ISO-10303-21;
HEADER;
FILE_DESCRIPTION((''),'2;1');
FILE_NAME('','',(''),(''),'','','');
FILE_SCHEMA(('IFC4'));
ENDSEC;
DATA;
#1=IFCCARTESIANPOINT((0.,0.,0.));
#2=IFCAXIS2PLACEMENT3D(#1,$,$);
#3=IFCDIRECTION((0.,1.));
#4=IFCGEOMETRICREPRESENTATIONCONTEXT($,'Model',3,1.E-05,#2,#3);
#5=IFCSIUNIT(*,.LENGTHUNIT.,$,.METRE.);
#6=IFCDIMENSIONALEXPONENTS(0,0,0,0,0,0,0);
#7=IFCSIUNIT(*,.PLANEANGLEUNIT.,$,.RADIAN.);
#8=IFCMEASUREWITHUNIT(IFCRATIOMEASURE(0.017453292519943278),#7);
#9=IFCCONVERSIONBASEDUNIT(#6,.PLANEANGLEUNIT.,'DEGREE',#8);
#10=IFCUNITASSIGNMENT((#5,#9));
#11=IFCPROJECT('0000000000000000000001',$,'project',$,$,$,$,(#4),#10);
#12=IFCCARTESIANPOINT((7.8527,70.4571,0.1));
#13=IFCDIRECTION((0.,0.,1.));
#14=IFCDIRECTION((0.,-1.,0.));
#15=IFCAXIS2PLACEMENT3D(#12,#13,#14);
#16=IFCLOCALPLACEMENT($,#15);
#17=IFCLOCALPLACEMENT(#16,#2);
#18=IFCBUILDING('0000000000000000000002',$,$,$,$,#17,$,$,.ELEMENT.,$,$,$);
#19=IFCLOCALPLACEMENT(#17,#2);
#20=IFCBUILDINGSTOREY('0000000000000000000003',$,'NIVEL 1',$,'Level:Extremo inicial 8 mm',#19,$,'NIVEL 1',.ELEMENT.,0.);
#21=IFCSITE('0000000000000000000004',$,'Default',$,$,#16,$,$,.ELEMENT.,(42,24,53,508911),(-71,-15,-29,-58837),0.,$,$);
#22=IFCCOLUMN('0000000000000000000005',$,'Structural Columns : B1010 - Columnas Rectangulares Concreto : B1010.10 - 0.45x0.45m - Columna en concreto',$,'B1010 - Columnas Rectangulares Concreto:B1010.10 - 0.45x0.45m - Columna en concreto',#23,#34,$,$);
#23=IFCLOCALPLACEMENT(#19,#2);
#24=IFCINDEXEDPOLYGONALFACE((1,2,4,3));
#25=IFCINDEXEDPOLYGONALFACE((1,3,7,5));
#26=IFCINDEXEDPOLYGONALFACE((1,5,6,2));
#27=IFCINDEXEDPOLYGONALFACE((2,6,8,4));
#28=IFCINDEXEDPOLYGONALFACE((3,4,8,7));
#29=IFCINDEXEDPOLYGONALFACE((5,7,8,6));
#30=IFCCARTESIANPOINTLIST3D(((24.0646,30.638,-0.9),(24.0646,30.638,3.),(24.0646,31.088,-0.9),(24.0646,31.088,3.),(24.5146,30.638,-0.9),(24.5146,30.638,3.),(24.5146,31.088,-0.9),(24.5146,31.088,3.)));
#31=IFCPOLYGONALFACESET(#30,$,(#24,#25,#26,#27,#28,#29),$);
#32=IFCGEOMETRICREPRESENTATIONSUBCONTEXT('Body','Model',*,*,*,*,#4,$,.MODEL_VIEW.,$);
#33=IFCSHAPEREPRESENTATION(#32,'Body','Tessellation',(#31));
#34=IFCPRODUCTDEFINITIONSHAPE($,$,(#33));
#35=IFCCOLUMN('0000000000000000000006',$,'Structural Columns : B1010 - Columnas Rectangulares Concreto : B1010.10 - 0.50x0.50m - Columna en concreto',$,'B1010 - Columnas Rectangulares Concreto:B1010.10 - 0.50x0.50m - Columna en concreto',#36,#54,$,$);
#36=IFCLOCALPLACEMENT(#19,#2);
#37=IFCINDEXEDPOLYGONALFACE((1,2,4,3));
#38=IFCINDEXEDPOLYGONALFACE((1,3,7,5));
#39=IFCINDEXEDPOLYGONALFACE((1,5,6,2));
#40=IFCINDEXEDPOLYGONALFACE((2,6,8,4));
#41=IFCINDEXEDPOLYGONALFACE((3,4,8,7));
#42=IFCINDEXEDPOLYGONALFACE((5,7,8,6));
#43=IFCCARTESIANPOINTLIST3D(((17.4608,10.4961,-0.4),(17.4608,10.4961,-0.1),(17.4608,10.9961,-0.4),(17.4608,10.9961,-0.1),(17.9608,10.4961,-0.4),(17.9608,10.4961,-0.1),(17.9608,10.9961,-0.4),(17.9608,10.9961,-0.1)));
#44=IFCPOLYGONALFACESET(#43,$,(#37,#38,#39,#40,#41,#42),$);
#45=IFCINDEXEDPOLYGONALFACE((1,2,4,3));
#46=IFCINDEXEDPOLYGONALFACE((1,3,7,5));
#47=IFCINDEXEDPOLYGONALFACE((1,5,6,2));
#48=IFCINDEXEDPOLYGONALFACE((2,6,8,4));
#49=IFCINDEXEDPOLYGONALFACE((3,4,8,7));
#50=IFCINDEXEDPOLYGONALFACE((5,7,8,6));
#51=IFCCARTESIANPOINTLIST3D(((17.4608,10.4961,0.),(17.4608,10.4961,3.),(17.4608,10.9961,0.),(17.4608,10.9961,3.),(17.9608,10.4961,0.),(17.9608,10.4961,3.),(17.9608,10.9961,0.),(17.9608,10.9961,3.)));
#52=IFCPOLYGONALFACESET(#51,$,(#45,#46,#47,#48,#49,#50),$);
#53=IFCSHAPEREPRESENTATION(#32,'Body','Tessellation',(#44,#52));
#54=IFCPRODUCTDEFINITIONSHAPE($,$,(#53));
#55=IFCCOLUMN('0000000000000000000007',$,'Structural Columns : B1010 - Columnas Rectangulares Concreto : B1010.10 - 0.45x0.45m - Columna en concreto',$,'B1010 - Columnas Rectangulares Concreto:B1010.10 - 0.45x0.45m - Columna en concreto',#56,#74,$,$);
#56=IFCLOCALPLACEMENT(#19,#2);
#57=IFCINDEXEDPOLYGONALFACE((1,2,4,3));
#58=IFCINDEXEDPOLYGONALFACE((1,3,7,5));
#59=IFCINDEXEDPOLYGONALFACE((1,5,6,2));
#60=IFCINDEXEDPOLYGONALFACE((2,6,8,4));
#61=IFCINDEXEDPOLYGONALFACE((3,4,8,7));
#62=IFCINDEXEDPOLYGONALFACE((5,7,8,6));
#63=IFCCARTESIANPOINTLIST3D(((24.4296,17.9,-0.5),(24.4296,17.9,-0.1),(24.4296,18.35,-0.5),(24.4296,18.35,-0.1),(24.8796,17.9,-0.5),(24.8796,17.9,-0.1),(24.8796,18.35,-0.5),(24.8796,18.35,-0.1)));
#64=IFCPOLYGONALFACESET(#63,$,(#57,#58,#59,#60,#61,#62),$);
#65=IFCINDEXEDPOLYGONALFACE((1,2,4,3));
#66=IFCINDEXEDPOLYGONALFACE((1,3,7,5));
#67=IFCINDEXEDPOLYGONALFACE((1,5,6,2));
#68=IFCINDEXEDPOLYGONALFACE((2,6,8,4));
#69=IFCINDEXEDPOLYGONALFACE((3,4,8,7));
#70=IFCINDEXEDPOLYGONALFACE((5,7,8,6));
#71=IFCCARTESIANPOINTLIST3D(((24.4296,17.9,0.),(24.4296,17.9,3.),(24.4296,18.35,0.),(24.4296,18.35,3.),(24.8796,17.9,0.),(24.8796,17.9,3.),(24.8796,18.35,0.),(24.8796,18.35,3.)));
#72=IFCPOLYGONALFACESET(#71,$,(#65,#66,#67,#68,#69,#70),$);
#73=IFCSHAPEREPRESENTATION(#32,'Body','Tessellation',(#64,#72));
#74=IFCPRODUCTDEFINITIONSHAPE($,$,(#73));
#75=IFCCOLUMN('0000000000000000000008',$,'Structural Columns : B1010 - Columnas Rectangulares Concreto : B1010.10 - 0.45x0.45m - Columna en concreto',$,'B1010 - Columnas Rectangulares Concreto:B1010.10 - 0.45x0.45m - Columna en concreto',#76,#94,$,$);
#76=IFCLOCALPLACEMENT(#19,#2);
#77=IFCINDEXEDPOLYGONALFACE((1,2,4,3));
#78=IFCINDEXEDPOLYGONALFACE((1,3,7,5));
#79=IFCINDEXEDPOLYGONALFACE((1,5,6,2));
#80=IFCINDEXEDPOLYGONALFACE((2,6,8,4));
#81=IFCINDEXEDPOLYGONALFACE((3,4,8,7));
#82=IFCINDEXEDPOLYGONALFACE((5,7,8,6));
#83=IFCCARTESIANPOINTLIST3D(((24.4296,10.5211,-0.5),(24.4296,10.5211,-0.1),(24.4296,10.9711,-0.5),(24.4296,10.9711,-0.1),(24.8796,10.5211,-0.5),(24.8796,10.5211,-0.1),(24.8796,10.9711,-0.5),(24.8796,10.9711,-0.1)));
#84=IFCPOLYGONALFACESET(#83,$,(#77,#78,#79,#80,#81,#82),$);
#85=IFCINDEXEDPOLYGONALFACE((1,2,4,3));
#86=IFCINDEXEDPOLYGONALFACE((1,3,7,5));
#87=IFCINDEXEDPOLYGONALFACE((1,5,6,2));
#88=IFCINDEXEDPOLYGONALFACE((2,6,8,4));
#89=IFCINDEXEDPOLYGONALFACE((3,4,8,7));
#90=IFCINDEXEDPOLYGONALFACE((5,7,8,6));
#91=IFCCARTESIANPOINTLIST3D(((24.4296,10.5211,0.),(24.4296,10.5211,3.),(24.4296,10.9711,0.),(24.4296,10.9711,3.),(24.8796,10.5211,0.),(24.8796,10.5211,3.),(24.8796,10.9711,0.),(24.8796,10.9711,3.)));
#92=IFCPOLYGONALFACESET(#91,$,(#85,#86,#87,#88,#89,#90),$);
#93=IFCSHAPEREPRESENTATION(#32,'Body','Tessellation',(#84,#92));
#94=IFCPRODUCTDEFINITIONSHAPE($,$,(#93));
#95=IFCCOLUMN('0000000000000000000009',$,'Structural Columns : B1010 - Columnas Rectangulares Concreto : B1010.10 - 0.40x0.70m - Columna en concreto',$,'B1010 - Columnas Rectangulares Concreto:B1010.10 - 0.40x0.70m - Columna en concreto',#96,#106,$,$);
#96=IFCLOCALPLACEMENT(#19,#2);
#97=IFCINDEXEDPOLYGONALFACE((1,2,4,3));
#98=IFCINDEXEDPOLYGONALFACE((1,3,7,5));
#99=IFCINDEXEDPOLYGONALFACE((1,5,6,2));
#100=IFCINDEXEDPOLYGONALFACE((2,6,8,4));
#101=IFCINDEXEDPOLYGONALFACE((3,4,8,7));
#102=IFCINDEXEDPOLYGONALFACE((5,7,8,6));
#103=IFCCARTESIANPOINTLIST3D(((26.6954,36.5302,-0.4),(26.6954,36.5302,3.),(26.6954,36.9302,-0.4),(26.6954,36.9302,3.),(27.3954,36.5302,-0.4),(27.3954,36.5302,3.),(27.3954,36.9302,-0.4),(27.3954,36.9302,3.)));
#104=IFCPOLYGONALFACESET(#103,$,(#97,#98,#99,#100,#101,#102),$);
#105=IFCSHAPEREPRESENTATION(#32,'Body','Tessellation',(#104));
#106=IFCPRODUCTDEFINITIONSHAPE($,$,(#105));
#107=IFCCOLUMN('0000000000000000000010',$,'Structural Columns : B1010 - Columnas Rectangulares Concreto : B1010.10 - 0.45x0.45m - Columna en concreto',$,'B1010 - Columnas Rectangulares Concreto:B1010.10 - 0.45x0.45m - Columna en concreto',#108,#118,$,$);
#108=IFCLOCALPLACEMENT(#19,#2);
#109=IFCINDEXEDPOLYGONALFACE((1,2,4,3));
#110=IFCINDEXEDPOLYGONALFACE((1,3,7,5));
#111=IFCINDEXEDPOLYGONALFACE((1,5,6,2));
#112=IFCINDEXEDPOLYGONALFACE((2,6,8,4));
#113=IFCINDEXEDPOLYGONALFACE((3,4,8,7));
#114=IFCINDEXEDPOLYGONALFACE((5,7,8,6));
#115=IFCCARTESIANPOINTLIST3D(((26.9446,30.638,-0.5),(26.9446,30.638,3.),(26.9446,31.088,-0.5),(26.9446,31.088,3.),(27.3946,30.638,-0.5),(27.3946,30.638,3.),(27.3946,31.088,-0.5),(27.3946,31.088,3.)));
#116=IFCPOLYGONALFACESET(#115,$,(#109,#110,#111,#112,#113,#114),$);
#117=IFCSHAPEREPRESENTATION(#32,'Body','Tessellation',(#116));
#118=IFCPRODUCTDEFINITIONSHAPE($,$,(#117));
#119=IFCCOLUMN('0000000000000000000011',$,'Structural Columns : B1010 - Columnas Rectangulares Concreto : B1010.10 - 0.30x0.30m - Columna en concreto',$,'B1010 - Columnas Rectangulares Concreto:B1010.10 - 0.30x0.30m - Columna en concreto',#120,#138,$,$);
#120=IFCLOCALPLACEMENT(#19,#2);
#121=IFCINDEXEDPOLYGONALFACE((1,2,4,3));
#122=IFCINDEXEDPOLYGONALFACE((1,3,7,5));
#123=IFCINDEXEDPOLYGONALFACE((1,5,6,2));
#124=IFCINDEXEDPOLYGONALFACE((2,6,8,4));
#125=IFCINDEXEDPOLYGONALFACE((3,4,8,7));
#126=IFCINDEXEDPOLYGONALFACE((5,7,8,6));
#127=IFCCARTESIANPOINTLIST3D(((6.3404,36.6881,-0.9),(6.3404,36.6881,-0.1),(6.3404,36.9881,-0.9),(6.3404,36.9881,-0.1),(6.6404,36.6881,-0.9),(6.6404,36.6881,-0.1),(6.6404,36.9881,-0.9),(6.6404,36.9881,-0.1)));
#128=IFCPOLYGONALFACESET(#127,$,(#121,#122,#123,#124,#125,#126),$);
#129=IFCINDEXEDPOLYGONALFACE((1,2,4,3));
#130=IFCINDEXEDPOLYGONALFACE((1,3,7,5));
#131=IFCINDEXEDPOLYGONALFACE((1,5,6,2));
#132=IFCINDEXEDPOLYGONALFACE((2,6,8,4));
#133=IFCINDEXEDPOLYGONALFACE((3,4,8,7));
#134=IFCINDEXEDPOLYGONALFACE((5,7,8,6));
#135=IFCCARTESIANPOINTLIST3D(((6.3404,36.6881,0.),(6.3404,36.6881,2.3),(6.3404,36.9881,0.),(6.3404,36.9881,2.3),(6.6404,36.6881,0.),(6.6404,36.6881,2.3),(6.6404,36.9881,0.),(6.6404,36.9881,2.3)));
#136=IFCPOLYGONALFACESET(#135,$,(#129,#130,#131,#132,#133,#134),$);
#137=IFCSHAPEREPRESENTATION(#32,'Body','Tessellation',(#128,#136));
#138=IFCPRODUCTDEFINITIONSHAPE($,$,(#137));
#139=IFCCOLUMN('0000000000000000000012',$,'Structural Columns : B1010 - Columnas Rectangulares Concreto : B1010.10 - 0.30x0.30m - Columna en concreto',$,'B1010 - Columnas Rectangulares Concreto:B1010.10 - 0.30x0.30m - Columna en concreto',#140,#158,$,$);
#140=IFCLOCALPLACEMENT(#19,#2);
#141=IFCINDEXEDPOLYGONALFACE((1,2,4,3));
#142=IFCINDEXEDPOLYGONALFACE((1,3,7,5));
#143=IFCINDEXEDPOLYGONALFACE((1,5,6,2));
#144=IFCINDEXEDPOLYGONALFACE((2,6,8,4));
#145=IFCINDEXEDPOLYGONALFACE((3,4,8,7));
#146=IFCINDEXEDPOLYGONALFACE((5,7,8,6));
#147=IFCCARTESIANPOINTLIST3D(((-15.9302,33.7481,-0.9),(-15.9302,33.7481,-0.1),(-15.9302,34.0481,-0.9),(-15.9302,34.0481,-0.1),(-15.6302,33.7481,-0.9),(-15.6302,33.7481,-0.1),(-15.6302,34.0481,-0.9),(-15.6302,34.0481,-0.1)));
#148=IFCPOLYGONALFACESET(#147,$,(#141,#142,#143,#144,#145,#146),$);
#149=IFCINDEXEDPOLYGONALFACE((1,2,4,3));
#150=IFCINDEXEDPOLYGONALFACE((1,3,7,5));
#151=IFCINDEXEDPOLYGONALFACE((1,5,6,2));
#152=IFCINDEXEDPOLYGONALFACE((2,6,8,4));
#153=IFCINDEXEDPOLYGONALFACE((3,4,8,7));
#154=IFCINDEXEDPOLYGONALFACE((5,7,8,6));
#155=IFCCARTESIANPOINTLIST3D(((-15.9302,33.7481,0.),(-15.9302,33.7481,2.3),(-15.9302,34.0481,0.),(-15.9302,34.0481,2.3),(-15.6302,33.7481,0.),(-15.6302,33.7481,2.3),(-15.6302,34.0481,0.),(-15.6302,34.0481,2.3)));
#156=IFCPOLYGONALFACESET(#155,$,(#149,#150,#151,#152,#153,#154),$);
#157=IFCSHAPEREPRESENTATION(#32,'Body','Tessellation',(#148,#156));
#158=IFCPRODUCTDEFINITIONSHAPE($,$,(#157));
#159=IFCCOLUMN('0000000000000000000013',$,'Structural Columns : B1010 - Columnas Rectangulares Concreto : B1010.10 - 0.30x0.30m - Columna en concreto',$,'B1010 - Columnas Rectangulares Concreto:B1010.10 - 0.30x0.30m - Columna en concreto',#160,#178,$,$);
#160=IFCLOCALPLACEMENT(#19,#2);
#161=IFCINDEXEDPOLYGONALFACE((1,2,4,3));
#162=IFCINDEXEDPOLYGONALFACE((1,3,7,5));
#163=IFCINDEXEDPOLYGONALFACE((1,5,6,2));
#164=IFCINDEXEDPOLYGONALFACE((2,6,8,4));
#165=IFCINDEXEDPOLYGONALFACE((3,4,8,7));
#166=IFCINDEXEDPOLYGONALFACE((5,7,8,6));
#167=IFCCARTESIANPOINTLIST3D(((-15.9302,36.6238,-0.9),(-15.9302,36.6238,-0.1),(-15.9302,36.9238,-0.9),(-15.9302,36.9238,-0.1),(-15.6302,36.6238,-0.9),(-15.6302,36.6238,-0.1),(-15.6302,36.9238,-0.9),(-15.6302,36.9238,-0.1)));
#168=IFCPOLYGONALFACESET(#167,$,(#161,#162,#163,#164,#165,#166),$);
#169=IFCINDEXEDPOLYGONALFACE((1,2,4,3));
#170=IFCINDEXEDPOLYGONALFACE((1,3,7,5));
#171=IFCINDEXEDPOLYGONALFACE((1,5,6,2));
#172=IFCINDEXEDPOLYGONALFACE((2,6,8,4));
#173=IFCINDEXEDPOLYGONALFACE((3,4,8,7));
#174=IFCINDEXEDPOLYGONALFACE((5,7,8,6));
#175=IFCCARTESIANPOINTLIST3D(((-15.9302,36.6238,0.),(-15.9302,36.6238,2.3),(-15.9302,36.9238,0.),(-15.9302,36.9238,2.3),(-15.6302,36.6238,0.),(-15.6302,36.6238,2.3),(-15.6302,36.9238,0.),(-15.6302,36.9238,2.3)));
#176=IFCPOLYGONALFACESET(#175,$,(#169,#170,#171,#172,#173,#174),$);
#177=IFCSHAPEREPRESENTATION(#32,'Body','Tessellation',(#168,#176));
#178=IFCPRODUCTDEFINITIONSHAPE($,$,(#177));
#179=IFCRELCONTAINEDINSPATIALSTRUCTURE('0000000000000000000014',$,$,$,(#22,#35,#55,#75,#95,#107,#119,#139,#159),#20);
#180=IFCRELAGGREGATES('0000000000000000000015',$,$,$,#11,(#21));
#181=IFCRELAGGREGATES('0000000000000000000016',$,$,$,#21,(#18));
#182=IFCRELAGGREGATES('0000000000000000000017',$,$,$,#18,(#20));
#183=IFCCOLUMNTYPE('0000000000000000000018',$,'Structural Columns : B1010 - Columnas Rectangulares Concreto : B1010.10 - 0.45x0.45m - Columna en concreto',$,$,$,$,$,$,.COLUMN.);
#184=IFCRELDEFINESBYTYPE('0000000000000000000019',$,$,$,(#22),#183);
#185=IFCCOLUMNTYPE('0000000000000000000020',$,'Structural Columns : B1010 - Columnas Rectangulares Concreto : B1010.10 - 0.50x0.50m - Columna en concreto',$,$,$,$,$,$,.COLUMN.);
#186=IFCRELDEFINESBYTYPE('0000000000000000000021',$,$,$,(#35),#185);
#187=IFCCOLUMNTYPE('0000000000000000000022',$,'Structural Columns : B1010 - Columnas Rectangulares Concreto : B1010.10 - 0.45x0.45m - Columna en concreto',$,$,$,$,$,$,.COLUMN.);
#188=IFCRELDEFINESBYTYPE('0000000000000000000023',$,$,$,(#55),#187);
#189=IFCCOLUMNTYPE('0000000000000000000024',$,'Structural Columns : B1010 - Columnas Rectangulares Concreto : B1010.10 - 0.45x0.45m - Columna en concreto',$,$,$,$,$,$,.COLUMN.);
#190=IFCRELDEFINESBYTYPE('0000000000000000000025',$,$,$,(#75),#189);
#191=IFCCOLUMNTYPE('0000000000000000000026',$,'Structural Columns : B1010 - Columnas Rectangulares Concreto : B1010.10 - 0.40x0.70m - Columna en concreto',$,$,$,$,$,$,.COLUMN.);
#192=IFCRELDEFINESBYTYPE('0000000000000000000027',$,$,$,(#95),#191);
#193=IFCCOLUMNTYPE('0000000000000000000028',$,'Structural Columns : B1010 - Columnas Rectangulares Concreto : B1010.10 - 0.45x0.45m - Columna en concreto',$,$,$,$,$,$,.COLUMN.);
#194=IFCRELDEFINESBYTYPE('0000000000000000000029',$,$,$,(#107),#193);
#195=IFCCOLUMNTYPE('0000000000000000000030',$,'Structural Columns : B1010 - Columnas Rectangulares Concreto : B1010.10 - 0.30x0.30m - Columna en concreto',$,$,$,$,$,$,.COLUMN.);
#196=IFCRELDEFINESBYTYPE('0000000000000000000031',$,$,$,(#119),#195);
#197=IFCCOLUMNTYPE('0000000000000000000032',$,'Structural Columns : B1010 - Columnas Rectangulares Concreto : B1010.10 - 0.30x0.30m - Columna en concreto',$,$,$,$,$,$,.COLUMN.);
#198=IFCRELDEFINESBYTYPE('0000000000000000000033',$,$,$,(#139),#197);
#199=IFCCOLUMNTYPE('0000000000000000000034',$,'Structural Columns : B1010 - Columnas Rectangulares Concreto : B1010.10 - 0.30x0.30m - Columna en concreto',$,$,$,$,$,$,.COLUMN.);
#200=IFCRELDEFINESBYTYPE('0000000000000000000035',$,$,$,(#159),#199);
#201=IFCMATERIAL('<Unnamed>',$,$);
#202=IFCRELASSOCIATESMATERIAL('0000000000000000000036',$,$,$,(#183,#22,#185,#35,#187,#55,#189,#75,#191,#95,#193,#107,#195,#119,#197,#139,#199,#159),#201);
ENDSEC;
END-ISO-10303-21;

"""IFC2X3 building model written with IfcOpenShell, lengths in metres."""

from ifc_helpers import new_model, entity, si_unit, converted_unit, direction, frame, frame_2d, origin, origin_2d_with_axis, place, context, subcontext, project, spatial, rectangle, extrude, source, transform, mapped, material, type_object, type_shapes, element, save


model = new_model("IFC2X3")

# Units and contexts
model_context = context("Model", 3, precision=1e-05, world=origin(), true_north=direction((0.0, 1.0)))
body_context = subcontext(model_context, "Body", "Model", "MODEL_VIEW")
ifc_project = project(units=[si_unit("LENGTHUNIT", "METRE"), converted_unit("PLANEANGLEUNIT", "DEGREE", entity("IfcRatioMeasure", 0.017453292519943278), si_unit("PLANEANGLEUNIT", "RADIAN"), dimensions=[0, 0, 0, 0, 0, 0, 0])], contexts=[model_context])

# Site, building, storey
site_placement = place(None, frame((7.8527, 70.4571, 0.1), z_axis=(0.0, 0.0, 1.0), x_axis=(0.0, -1.0, 0.0)))
site = spatial("IfcSite", under=ifc_project, at=site_placement, Name="Default", CompositionType="ELEMENT", RefLatitude=(42, 24, 53, 508911), RefLongitude=(-71, -15, -29, -58837), RefElevation=0.0)
building_placement = place(site_placement, origin())
building = spatial("IfcBuilding", under=site, at=building_placement, CompositionType="ELEMENT")
storey_placement = place(building_placement, origin())
storey = spatial("IfcBuildingStorey", under=building, at=storey_placement, Name="NIVEL 1", ObjectType="Level:Extremo inicial 8 mm", LongName="NIVEL 1", CompositionType="ELEMENT", Elevation=0.0)

# Columns
ifc_material_1 = material(Name="<Unnamed>")
column_type_1 = type_object("IfcColumnType", Name="Structural Columns : B1010 - Columnas Rectangulares Concreto : B1010.10 - 0.45x0.45m - Columna en concreto", PredefinedType="COLUMN", material=ifc_material_1)
shared_shape_1 = source(origin(), body_context, "Body", "SweptSolid", [
    extrude(rectangle(XDim=0.45, YDim=0.45, at=origin_2d_with_axis()), frame((24.2896, 30.863, -0.9), z_axis=(0.0, 0.0, 1.0), x_axis=(0.0, -1.0, 0.0)), (0.0, 0.0, 1.0), 3.9),
])
type_shapes(column_type_1, [shared_shape_1])
column_1_placement = place(storey_placement, origin())
element("IfcColumn", 1, at=column_1_placement, inside=storey, type_object=column_type_1, material=ifc_material_1, Name="Structural Columns : B1010 - Columnas Rectangulares Concreto : B1010.10 - 0.45x0.45m - Columna en concreto", ObjectType="B1010 - Columnas Rectangulares Concreto:B1010.10 - 0.45x0.45m - Columna en concreto", context=body_context, shape_type="MappedRepresentation", body=[
    mapped(shared_shape_1, transform((0.0, 0.0, 0.0), scale=1.0)),
])
column_type_2 = type_object("IfcColumnType", Name="Structural Columns : B1010 - Columnas Rectangulares Concreto : B1010.10 - 0.50x0.50m - Columna en concreto", PredefinedType="COLUMN", material=ifc_material_1)
shared_shape_2 = source(origin(), body_context, "Body", "SweptSolid", [
    extrude(rectangle(XDim=0.5, YDim=0.5, at=origin_2d_with_axis()), frame((17.7108, 10.7461, -0.4), z_axis=(0.0, 0.0, 1.0), x_axis=(0.0, -1.0, 0.0)), (0.0, 0.0, 1.0), 0.3),
    extrude(rectangle(XDim=0.5, YDim=0.5, at=origin_2d_with_axis()), frame((17.7108, 10.7461, 0.0), z_axis=(0.0, 0.0, 1.0), x_axis=(0.0, -1.0, 0.0)), (0.0, 0.0, 1.0), 3.0),
])
type_shapes(column_type_2, [shared_shape_2])
column_2_placement = place(storey_placement, origin())
element("IfcColumn", 2, at=column_2_placement, inside=storey, type_object=column_type_2, material=ifc_material_1, Name="Structural Columns : B1010 - Columnas Rectangulares Concreto : B1010.10 - 0.50x0.50m - Columna en concreto", ObjectType="B1010 - Columnas Rectangulares Concreto:B1010.10 - 0.50x0.50m - Columna en concreto", context=body_context, shape_type="MappedRepresentation", body=[
    mapped(shared_shape_2, transform((0.0, 0.0, 0.0), scale=1.0)),
])
column_type_3 = type_object("IfcColumnType", Name="Structural Columns : B1010 - Columnas Rectangulares Concreto : B1010.10 - 0.45x0.45m - Columna en concreto", PredefinedType="COLUMN", material=ifc_material_1)
shared_shape_3 = source(origin(), body_context, "Body", "SweptSolid", [
    extrude(rectangle(XDim=0.45, YDim=0.45, at=origin_2d_with_axis()), frame((24.6546, 18.125, -0.5), z_axis=(0.0, 0.0, 1.0), x_axis=(0.0, -1.0, 0.0)), (0.0, 0.0, 1.0), 0.4),
    extrude(rectangle(XDim=0.45, YDim=0.45, at=origin_2d_with_axis()), frame((24.6546, 18.125, 0.0), z_axis=(0.0, 0.0, 1.0), x_axis=(0.0, -1.0, 0.0)), (0.0, 0.0, 1.0), 3.0),
])
type_shapes(column_type_3, [shared_shape_3])
column_3_placement = place(storey_placement, origin())
element("IfcColumn", 3, at=column_3_placement, inside=storey, type_object=column_type_3, material=ifc_material_1, Name="Structural Columns : B1010 - Columnas Rectangulares Concreto : B1010.10 - 0.45x0.45m - Columna en concreto", ObjectType="B1010 - Columnas Rectangulares Concreto:B1010.10 - 0.45x0.45m - Columna en concreto", context=body_context, shape_type="MappedRepresentation", body=[
    mapped(shared_shape_3, transform((0.0, 0.0, 0.0), scale=1.0)),
])
column_type_4 = type_object("IfcColumnType", Name="Structural Columns : B1010 - Columnas Rectangulares Concreto : B1010.10 - 0.45x0.45m - Columna en concreto", PredefinedType="COLUMN", material=ifc_material_1)
shared_shape_4 = source(origin(), body_context, "Body", "SweptSolid", [
    extrude(rectangle(XDim=0.45, YDim=0.45, at=origin_2d_with_axis()), frame((24.6546, 10.7461, -0.5), z_axis=(0.0, 0.0, 1.0), x_axis=(0.0, -1.0, 0.0)), (0.0, 0.0, 1.0), 0.4),
    extrude(rectangle(XDim=0.45, YDim=0.45, at=origin_2d_with_axis()), frame((24.6546, 10.7461, 0.0), z_axis=(0.0, 0.0, 1.0), x_axis=(0.0, -1.0, 0.0)), (0.0, 0.0, 1.0), 3.0),
])
type_shapes(column_type_4, [shared_shape_4])
column_4_placement = place(storey_placement, origin())
element("IfcColumn", 4, at=column_4_placement, inside=storey, type_object=column_type_4, material=ifc_material_1, Name="Structural Columns : B1010 - Columnas Rectangulares Concreto : B1010.10 - 0.45x0.45m - Columna en concreto", ObjectType="B1010 - Columnas Rectangulares Concreto:B1010.10 - 0.45x0.45m - Columna en concreto", context=body_context, shape_type="MappedRepresentation", body=[
    mapped(shared_shape_4, transform((0.0, 0.0, 0.0), scale=1.0)),
])
column_type_5 = type_object("IfcColumnType", Name="Structural Columns : B1010 - Columnas Rectangulares Concreto : B1010.10 - 0.40x0.70m - Columna en concreto", PredefinedType="COLUMN", material=ifc_material_1)
shared_shape_5 = source(origin(), body_context, "Body", "SweptSolid", [
    extrude(rectangle(XDim=0.4, YDim=0.7, at=origin_2d_with_axis()), frame((27.0454, 36.7302, -0.4), z_axis=(0.0, 0.0, 1.0), x_axis=(0.0, -1.0, 0.0)), (0.0, 0.0, 1.0), 3.4),
])
type_shapes(column_type_5, [shared_shape_5])
column_5_placement = place(storey_placement, origin())
element("IfcColumn", 5, at=column_5_placement, inside=storey, type_object=column_type_5, material=ifc_material_1, Name="Structural Columns : B1010 - Columnas Rectangulares Concreto : B1010.10 - 0.40x0.70m - Columna en concreto", ObjectType="B1010 - Columnas Rectangulares Concreto:B1010.10 - 0.40x0.70m - Columna en concreto", context=body_context, shape_type="MappedRepresentation", body=[
    mapped(shared_shape_5, transform((0.0, 0.0, 0.0), scale=1.0)),
])
column_type_6 = type_object("IfcColumnType", Name="Structural Columns : B1010 - Columnas Rectangulares Concreto : B1010.10 - 0.45x0.45m - Columna en concreto", PredefinedType="COLUMN", material=ifc_material_1)
shared_shape_6 = source(origin(), body_context, "Body", "SweptSolid", [
    extrude(rectangle(XDim=0.45, YDim=0.45, at=origin_2d_with_axis()), frame((27.1696, 30.863, -0.5), z_axis=(0.0, 0.0, 1.0), x_axis=(0.0, -1.0, 0.0)), (0.0, 0.0, 1.0), 3.5),
])
type_shapes(column_type_6, [shared_shape_6])
column_6_placement = place(storey_placement, origin())
element("IfcColumn", 6, at=column_6_placement, inside=storey, type_object=column_type_6, material=ifc_material_1, Name="Structural Columns : B1010 - Columnas Rectangulares Concreto : B1010.10 - 0.45x0.45m - Columna en concreto", ObjectType="B1010 - Columnas Rectangulares Concreto:B1010.10 - 0.45x0.45m - Columna en concreto", context=body_context, shape_type="MappedRepresentation", body=[
    mapped(shared_shape_6, transform((0.0, 0.0, 0.0), scale=1.0)),
])
column_type_7 = type_object("IfcColumnType", Name="Structural Columns : B1010 - Columnas Rectangulares Concreto : B1010.10 - 0.30x0.30m - Columna en concreto", PredefinedType="COLUMN", material=ifc_material_1)
shared_shape_7 = source(origin(), body_context, "Body", "SweptSolid", [
    extrude(rectangle(XDim=0.3, YDim=0.3, at=frame_2d((0.0, 0.0), x_axis=(1.0, 0.0))), frame((6.4904, 36.8381, -0.9), z_axis=(0.0, 0.0, 1.0), x_axis=(0.0, -1.0, 0.0)), (0.0, 0.0, 1.0), 0.8),
    extrude(rectangle(XDim=0.3, YDim=0.3, at=frame_2d((0.0, 0.0), x_axis=(1.0, 0.0))), frame((6.4904, 36.8381, 0.0), z_axis=(0.0, 0.0, 1.0), x_axis=(0.0, -1.0, 0.0)), (0.0, 0.0, 1.0), 2.3),
])
type_shapes(column_type_7, [shared_shape_7])
column_7_placement = place(storey_placement, origin())
element("IfcColumn", 7, at=column_7_placement, inside=storey, type_object=column_type_7, material=ifc_material_1, Name="Structural Columns : B1010 - Columnas Rectangulares Concreto : B1010.10 - 0.30x0.30m - Columna en concreto", ObjectType="B1010 - Columnas Rectangulares Concreto:B1010.10 - 0.30x0.30m - Columna en concreto", context=body_context, shape_type="MappedRepresentation", body=[
    mapped(shared_shape_7, transform((0.0, 0.0, 0.0), scale=1.0)),
])
column_type_8 = type_object("IfcColumnType", Name="Structural Columns : B1010 - Columnas Rectangulares Concreto : B1010.10 - 0.30x0.30m - Columna en concreto", PredefinedType="COLUMN", material=ifc_material_1)
shared_shape_8 = source(origin(), body_context, "Body", "SweptSolid", [
    extrude(rectangle(XDim=0.3, YDim=0.3, at=origin_2d_with_axis()), frame((-15.7802, 33.8981, -0.9), z_axis=(0.0, 0.0, 1.0), x_axis=(0.0, -1.0, 0.0)), (0.0, 0.0, 1.0), 0.8),
    extrude(rectangle(XDim=0.3, YDim=0.3, at=origin_2d_with_axis()), frame((-15.7802, 33.8981, 0.0), z_axis=(0.0, 0.0, 1.0), x_axis=(0.0, -1.0, 0.0)), (0.0, 0.0, 1.0), 2.3),
])
type_shapes(column_type_8, [shared_shape_8])
column_8_placement = place(storey_placement, origin())
element("IfcColumn", 8, at=column_8_placement, inside=storey, type_object=column_type_8, material=ifc_material_1, Name="Structural Columns : B1010 - Columnas Rectangulares Concreto : B1010.10 - 0.30x0.30m - Columna en concreto", ObjectType="B1010 - Columnas Rectangulares Concreto:B1010.10 - 0.30x0.30m - Columna en concreto", context=body_context, shape_type="MappedRepresentation", body=[
    mapped(shared_shape_8, transform((0.0, 0.0, 0.0), scale=1.0)),
])
column_type_9 = type_object("IfcColumnType", Name="Structural Columns : B1010 - Columnas Rectangulares Concreto : B1010.10 - 0.30x0.30m - Columna en concreto", PredefinedType="COLUMN", material=ifc_material_1)
shared_shape_9 = source(origin(), body_context, "Body", "SweptSolid", [
    extrude(rectangle(XDim=0.3, YDim=0.3, at=origin_2d_with_axis()), frame((-15.7802, 36.7738, -0.9), z_axis=(0.0, 0.0, 1.0), x_axis=(0.0, -1.0, 0.0)), (0.0, 0.0, 1.0), 0.8),
    extrude(rectangle(XDim=0.3, YDim=0.3, at=origin_2d_with_axis()), frame((-15.7802, 36.7738, 0.0), z_axis=(0.0, 0.0, 1.0), x_axis=(0.0, -1.0, 0.0)), (0.0, 0.0, 1.0), 2.3),
])
type_shapes(column_type_9, [shared_shape_9])
column_9_placement = place(storey_placement, origin())
element("IfcColumn", 9, at=column_9_placement, inside=storey, type_object=column_type_9, material=ifc_material_1, Name="Structural Columns : B1010 - Columnas Rectangulares Concreto : B1010.10 - 0.30x0.30m - Columna en concreto", ObjectType="B1010 - Columnas Rectangulares Concreto:B1010.10 - 0.30x0.30m - Columna en concreto", context=body_context, shape_type="MappedRepresentation", body=[
    mapped(shared_shape_9, transform((0.0, 0.0, 0.0), scale=1.0)),
])

save(model, "model.ifc")
